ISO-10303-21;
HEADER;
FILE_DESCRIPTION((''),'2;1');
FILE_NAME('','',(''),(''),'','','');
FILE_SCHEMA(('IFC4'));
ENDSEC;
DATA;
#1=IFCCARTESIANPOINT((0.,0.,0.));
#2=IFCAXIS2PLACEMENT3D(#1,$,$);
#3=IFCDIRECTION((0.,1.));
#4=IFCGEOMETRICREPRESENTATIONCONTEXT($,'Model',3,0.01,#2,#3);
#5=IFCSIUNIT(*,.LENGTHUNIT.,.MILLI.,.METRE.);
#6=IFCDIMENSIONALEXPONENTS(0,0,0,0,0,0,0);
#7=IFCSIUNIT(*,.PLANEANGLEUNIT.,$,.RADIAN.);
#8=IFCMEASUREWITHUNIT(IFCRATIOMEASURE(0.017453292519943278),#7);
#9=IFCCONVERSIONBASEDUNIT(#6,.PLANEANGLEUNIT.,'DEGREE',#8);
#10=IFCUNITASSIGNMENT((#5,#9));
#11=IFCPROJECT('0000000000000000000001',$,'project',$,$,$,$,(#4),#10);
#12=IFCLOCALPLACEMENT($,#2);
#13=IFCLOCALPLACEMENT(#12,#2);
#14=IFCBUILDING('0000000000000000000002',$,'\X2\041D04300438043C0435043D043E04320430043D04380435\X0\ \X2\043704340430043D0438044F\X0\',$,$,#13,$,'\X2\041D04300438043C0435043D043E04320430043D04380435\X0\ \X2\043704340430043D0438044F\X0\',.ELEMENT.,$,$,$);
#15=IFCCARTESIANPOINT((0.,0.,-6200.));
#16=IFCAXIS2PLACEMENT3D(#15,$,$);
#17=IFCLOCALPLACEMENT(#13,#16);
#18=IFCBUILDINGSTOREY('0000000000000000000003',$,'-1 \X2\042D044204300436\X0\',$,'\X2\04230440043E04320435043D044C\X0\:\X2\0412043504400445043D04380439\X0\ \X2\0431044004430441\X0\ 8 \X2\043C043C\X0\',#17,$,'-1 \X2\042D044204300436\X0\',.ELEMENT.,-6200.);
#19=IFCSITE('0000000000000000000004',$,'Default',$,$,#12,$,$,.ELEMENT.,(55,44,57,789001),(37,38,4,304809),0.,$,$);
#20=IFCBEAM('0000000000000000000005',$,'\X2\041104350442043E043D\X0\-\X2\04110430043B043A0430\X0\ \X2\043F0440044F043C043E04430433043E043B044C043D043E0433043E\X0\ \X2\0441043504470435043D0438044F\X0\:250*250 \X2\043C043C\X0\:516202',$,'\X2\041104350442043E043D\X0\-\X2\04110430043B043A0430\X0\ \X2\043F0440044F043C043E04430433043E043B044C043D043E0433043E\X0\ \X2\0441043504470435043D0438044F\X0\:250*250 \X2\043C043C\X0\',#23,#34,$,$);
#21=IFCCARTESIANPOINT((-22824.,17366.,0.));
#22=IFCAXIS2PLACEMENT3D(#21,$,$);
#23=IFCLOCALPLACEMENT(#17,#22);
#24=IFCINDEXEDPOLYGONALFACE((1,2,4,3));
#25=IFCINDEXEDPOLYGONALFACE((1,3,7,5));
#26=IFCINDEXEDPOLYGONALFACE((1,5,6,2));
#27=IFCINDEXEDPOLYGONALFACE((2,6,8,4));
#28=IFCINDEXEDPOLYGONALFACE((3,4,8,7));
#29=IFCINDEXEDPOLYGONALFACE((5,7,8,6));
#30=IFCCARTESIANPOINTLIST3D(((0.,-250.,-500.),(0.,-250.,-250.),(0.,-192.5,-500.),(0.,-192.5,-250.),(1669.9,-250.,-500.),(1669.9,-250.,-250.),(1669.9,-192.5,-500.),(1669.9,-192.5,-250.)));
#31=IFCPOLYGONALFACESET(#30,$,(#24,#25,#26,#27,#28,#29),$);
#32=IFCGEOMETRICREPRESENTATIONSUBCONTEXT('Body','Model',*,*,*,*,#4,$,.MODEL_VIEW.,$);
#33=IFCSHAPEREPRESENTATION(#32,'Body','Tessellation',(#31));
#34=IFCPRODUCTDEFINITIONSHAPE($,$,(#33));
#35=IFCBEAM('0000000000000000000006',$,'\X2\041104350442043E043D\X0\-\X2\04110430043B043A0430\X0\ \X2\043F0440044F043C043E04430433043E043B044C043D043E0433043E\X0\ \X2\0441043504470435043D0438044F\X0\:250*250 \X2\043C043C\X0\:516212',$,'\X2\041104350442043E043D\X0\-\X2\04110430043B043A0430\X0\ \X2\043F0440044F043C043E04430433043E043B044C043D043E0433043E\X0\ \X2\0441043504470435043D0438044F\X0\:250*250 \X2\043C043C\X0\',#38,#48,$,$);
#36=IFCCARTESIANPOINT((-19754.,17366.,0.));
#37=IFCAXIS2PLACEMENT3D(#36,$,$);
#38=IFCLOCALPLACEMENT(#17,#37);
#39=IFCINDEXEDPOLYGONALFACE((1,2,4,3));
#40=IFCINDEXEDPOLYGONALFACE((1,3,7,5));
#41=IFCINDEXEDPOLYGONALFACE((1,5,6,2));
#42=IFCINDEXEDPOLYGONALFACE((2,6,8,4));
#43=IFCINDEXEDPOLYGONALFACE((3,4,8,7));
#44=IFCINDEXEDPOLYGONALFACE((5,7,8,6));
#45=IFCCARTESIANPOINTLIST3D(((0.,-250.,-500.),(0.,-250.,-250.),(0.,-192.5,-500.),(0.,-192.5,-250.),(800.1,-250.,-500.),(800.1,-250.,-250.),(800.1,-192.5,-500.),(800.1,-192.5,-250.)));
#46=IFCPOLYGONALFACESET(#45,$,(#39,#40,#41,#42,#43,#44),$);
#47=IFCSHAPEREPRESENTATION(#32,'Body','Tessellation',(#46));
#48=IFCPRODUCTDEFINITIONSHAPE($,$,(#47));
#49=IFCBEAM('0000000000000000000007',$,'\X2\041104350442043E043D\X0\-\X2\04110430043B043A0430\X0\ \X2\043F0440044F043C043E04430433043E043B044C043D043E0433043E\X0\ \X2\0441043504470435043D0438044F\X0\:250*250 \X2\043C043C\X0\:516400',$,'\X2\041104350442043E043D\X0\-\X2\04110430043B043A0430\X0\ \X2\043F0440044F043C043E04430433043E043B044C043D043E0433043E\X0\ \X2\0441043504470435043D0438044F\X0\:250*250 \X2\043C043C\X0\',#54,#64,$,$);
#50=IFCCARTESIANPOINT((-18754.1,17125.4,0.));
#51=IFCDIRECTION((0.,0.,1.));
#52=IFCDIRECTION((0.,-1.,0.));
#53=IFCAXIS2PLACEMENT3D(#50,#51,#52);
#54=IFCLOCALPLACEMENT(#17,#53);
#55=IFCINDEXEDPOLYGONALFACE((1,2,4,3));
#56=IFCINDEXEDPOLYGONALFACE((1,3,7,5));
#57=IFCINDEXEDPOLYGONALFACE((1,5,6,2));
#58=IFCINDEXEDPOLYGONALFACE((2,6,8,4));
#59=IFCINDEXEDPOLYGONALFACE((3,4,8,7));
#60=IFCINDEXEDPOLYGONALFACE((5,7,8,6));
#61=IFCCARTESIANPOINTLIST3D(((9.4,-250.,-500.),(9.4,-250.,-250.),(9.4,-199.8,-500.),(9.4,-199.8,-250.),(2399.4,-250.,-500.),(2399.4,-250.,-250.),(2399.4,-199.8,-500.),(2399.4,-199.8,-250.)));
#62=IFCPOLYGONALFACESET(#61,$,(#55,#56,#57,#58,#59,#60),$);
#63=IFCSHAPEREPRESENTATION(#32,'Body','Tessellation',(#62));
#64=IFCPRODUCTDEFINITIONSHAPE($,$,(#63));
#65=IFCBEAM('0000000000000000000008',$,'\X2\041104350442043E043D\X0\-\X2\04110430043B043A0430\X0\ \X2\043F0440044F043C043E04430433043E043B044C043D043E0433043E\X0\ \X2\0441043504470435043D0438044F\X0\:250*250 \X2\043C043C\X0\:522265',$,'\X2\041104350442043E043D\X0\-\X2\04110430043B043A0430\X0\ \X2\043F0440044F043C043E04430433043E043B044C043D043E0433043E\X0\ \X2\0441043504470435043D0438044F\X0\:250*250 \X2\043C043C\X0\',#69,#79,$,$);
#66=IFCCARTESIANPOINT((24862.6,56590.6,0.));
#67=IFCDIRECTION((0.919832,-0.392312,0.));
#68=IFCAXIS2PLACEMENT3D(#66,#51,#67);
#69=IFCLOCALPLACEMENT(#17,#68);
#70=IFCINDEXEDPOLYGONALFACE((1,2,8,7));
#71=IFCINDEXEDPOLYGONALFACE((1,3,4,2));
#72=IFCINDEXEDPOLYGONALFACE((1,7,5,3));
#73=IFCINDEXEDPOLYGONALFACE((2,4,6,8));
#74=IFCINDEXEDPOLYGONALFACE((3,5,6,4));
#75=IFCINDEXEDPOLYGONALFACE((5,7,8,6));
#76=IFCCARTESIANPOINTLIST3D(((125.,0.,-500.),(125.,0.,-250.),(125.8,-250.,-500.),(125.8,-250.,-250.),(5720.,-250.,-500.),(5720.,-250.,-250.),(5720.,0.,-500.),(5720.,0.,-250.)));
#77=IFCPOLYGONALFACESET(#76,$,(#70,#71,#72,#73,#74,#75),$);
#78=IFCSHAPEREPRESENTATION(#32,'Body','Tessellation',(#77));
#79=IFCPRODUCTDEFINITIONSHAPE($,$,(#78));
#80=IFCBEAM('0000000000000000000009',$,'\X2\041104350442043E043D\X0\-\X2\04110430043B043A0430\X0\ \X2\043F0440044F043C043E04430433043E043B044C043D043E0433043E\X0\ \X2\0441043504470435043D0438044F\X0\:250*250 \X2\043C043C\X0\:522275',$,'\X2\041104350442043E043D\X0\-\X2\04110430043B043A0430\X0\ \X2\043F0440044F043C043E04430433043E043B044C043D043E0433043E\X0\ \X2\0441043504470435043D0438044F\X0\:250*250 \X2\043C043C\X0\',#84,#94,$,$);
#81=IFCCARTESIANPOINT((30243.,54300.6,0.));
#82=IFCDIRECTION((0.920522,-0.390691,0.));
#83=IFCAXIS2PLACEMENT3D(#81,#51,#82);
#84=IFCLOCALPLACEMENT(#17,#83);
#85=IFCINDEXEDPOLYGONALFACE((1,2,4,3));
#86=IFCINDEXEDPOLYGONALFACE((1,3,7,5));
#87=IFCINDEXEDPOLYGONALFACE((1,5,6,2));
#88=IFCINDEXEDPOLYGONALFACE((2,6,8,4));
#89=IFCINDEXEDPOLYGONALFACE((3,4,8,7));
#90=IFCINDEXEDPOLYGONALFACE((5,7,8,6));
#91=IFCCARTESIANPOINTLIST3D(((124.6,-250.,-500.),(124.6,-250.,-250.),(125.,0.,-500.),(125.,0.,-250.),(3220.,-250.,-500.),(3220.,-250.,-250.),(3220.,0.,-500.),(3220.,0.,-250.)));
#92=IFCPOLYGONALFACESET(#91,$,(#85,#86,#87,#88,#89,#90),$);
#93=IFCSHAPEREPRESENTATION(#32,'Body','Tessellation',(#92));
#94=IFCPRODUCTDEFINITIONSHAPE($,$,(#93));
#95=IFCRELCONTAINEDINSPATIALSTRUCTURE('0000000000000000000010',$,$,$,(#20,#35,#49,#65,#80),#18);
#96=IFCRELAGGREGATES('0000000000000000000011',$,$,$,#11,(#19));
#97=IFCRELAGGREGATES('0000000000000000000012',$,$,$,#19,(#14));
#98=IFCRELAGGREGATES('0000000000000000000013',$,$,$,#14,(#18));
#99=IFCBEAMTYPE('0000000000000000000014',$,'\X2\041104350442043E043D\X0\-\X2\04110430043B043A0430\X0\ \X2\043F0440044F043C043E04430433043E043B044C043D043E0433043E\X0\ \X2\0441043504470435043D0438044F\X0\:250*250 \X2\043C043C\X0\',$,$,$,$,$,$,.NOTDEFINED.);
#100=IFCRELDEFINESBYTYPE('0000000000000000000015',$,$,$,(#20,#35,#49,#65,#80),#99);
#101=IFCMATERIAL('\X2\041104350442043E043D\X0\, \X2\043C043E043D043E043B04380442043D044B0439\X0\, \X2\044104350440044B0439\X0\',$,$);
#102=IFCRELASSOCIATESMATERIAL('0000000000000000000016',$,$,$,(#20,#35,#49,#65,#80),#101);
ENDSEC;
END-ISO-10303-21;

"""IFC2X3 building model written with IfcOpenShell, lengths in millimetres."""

from ifc_helpers import new_model, entity, si_unit, converted_unit, direction, frame, frame_2d, origin, origin_2d_with_axis, place, context, subcontext, project, spatial, rectangle, extrude, clip, halfspace, material, type_object, element, save


model = new_model("IFC2X3")

# Units and contexts
model_context = context("Model", 3, precision=0.01, world=origin(), true_north=direction((0.0, 1.0)))
body_context = subcontext(model_context, "Body", "Model", "MODEL_VIEW")
ifc_project = project(units=[si_unit("LENGTHUNIT", "METRE", prefix="MILLI"), converted_unit("PLANEANGLEUNIT", "DEGREE", entity("IfcRatioMeasure", 0.017453292519943278), si_unit("PLANEANGLEUNIT", "RADIAN"), dimensions=[0, 0, 0, 0, 0, 0, 0])], contexts=[model_context])

# Site, building, storey
site_placement = place(None, origin())
site = spatial("IfcSite", under=ifc_project, at=site_placement, Name="Default", CompositionType="ELEMENT", RefLatitude=(55, 44, 57, 789001), RefLongitude=(37, 38, 4, 304809), RefElevation=0.0)
building_placement = place(site_placement, origin())
building = spatial("IfcBuilding", under=site, at=building_placement, Name="Наименование здания", LongName="Наименование здания", CompositionType="ELEMENT")
storey_placement = place(building_placement, frame((0.0, 0.0, -6200.0)))
storey = spatial("IfcBuildingStorey", under=building, at=storey_placement, Name="-1 Этаж", ObjectType="Уровень:Верхний брус 8 мм", LongName="-1 Этаж", CompositionType="ELEMENT", Elevation=-6200.0)

# Beams
ifc_material_1 = material(Name="Бетон, монолитный, серый")
beam_type_1 = type_object("IfcBeamType", Name="Бетон-Балка прямоугольного сечения:250*250 мм", PredefinedType="NOTDEFINED")
beam_1_placement = place(storey_placement, frame((-22824.0, 17366.0, 0.0)))
element("IfcBeam", 1, at=beam_1_placement, inside=storey, type_object=beam_type_1, material=ifc_material_1, Name="Бетон-Балка прямоугольного сечения:250*250 мм:516202", ObjectType="Бетон-Балка прямоугольного сечения:250*250 мм", context=body_context, shape_type="SweptSolid", body=[
    extrude(rectangle(XDim=250.0, YDim=57.5, at=origin_2d_with_axis()), frame((0.0, -221.3, -375.0), z_axis=(1.0, 0.0, 0.0), x_axis=(0.0, 0.0, -1.0)), (0.0, 0.0, 1.0), 1669.9),
])
beam_2_placement = place(storey_placement, frame((-19754.0, 17366.0, 0.0)))
element("IfcBeam", 2, at=beam_2_placement, inside=storey, type_object=beam_type_1, material=ifc_material_1, Name="Бетон-Балка прямоугольного сечения:250*250 мм:516212", ObjectType="Бетон-Балка прямоугольного сечения:250*250 мм", context=body_context, shape_type="SweptSolid", body=[
    extrude(rectangle(XDim=250.0, YDim=57.5, at=origin_2d_with_axis()), frame((0.0, -221.3, -375.0), z_axis=(1.0, 0.0, 0.0), x_axis=(0.0, 0.0, -1.0)), (0.0, 0.0, 1.0), 800.1),
])
beam_3_placement = place(storey_placement, frame((-18754.1, 17125.4, 0.0), z_axis=(0.0, 0.0, 1.0), x_axis=(0.0, -1.0, 0.0)))
element("IfcBeam", 3, at=beam_3_placement, inside=storey, type_object=beam_type_1, material=ifc_material_1, Name="Бетон-Балка прямоугольного сечения:250*250 мм:516400", ObjectType="Бетон-Балка прямоугольного сечения:250*250 мм", context=body_context, shape_type="SweptSolid", body=[
    extrude(rectangle(XDim=250.0, YDim=50.2, at=frame_2d((0.0, 0.0), x_axis=(1.0, 0.0))), frame((9.4, -224.9, -375.0), z_axis=(1.0, 0.0, 0.0), x_axis=(0.0, 0.0, -1.0)), (0.0, 0.0, 1.0), 2390.0),
])
beam_4_placement = place(storey_placement, frame((24862.6, 56590.6, 0.0), z_axis=(0.0, 0.0, 1.0), x_axis=(0.919832, -0.392312, 0.0)))
element("IfcBeam", 4, at=beam_4_placement, inside=storey, type_object=beam_type_1, material=ifc_material_1, Name="Бетон-Балка прямоугольного сечения:250*250 мм:522265", ObjectType="Бетон-Балка прямоугольного сечения:250*250 мм", context=body_context, shape_type="SweptSolid", body=[
    clip(extrude(rectangle(XDim=250.0, YDim=250.0, at=frame_2d((0.0, 0.0), x_axis=(1.0, 0.0))), frame((125.0, -125.0, -375.0), z_axis=(1.0, 0.0, 0.0), x_axis=(0.0, 0.0, -1.0)), (0.0, 0.0, 1.0), 5595.0), halfspace(frame((57.7, 21478.9, -3750.0), z_axis=(-0.999995, -0.003133, 0.0), x_axis=(-0.003133, 0.999995, 0.0)), False)),
])
beam_5_placement = place(storey_placement, frame((30243.0, 54300.6, 0.0), z_axis=(0.0, 0.0, 1.0), x_axis=(0.920522, -0.390691, 0.0)))
element("IfcBeam", 5, at=beam_5_placement, inside=storey, type_object=beam_type_1, material=ifc_material_1, Name="Бетон-Балка прямоугольного сечения:250*250 мм:522275", ObjectType="Бетон-Балка прямоугольного сечения:250*250 мм", context=body_context, shape_type="SweptSolid", body=[
    clip(extrude(rectangle(XDim=250.0, YDim=250.0, at=frame_2d((0.0, 0.0), x_axis=(1.0, 0.0))), frame((124.6, -125.0, -375.0), z_axis=(1.0, 0.0, 0.0), x_axis=(0.0, 0.0, -1.0)), (0.0, 0.0, 1.0), 3095.4), halfspace(frame((161.0, 20426.4, -3750.0), z_axis=(-0.999998, 0.001762, 0.0), x_axis=(0.001762, 0.999998, 0.0)), False)),
])

save(model, "model.ifc")
